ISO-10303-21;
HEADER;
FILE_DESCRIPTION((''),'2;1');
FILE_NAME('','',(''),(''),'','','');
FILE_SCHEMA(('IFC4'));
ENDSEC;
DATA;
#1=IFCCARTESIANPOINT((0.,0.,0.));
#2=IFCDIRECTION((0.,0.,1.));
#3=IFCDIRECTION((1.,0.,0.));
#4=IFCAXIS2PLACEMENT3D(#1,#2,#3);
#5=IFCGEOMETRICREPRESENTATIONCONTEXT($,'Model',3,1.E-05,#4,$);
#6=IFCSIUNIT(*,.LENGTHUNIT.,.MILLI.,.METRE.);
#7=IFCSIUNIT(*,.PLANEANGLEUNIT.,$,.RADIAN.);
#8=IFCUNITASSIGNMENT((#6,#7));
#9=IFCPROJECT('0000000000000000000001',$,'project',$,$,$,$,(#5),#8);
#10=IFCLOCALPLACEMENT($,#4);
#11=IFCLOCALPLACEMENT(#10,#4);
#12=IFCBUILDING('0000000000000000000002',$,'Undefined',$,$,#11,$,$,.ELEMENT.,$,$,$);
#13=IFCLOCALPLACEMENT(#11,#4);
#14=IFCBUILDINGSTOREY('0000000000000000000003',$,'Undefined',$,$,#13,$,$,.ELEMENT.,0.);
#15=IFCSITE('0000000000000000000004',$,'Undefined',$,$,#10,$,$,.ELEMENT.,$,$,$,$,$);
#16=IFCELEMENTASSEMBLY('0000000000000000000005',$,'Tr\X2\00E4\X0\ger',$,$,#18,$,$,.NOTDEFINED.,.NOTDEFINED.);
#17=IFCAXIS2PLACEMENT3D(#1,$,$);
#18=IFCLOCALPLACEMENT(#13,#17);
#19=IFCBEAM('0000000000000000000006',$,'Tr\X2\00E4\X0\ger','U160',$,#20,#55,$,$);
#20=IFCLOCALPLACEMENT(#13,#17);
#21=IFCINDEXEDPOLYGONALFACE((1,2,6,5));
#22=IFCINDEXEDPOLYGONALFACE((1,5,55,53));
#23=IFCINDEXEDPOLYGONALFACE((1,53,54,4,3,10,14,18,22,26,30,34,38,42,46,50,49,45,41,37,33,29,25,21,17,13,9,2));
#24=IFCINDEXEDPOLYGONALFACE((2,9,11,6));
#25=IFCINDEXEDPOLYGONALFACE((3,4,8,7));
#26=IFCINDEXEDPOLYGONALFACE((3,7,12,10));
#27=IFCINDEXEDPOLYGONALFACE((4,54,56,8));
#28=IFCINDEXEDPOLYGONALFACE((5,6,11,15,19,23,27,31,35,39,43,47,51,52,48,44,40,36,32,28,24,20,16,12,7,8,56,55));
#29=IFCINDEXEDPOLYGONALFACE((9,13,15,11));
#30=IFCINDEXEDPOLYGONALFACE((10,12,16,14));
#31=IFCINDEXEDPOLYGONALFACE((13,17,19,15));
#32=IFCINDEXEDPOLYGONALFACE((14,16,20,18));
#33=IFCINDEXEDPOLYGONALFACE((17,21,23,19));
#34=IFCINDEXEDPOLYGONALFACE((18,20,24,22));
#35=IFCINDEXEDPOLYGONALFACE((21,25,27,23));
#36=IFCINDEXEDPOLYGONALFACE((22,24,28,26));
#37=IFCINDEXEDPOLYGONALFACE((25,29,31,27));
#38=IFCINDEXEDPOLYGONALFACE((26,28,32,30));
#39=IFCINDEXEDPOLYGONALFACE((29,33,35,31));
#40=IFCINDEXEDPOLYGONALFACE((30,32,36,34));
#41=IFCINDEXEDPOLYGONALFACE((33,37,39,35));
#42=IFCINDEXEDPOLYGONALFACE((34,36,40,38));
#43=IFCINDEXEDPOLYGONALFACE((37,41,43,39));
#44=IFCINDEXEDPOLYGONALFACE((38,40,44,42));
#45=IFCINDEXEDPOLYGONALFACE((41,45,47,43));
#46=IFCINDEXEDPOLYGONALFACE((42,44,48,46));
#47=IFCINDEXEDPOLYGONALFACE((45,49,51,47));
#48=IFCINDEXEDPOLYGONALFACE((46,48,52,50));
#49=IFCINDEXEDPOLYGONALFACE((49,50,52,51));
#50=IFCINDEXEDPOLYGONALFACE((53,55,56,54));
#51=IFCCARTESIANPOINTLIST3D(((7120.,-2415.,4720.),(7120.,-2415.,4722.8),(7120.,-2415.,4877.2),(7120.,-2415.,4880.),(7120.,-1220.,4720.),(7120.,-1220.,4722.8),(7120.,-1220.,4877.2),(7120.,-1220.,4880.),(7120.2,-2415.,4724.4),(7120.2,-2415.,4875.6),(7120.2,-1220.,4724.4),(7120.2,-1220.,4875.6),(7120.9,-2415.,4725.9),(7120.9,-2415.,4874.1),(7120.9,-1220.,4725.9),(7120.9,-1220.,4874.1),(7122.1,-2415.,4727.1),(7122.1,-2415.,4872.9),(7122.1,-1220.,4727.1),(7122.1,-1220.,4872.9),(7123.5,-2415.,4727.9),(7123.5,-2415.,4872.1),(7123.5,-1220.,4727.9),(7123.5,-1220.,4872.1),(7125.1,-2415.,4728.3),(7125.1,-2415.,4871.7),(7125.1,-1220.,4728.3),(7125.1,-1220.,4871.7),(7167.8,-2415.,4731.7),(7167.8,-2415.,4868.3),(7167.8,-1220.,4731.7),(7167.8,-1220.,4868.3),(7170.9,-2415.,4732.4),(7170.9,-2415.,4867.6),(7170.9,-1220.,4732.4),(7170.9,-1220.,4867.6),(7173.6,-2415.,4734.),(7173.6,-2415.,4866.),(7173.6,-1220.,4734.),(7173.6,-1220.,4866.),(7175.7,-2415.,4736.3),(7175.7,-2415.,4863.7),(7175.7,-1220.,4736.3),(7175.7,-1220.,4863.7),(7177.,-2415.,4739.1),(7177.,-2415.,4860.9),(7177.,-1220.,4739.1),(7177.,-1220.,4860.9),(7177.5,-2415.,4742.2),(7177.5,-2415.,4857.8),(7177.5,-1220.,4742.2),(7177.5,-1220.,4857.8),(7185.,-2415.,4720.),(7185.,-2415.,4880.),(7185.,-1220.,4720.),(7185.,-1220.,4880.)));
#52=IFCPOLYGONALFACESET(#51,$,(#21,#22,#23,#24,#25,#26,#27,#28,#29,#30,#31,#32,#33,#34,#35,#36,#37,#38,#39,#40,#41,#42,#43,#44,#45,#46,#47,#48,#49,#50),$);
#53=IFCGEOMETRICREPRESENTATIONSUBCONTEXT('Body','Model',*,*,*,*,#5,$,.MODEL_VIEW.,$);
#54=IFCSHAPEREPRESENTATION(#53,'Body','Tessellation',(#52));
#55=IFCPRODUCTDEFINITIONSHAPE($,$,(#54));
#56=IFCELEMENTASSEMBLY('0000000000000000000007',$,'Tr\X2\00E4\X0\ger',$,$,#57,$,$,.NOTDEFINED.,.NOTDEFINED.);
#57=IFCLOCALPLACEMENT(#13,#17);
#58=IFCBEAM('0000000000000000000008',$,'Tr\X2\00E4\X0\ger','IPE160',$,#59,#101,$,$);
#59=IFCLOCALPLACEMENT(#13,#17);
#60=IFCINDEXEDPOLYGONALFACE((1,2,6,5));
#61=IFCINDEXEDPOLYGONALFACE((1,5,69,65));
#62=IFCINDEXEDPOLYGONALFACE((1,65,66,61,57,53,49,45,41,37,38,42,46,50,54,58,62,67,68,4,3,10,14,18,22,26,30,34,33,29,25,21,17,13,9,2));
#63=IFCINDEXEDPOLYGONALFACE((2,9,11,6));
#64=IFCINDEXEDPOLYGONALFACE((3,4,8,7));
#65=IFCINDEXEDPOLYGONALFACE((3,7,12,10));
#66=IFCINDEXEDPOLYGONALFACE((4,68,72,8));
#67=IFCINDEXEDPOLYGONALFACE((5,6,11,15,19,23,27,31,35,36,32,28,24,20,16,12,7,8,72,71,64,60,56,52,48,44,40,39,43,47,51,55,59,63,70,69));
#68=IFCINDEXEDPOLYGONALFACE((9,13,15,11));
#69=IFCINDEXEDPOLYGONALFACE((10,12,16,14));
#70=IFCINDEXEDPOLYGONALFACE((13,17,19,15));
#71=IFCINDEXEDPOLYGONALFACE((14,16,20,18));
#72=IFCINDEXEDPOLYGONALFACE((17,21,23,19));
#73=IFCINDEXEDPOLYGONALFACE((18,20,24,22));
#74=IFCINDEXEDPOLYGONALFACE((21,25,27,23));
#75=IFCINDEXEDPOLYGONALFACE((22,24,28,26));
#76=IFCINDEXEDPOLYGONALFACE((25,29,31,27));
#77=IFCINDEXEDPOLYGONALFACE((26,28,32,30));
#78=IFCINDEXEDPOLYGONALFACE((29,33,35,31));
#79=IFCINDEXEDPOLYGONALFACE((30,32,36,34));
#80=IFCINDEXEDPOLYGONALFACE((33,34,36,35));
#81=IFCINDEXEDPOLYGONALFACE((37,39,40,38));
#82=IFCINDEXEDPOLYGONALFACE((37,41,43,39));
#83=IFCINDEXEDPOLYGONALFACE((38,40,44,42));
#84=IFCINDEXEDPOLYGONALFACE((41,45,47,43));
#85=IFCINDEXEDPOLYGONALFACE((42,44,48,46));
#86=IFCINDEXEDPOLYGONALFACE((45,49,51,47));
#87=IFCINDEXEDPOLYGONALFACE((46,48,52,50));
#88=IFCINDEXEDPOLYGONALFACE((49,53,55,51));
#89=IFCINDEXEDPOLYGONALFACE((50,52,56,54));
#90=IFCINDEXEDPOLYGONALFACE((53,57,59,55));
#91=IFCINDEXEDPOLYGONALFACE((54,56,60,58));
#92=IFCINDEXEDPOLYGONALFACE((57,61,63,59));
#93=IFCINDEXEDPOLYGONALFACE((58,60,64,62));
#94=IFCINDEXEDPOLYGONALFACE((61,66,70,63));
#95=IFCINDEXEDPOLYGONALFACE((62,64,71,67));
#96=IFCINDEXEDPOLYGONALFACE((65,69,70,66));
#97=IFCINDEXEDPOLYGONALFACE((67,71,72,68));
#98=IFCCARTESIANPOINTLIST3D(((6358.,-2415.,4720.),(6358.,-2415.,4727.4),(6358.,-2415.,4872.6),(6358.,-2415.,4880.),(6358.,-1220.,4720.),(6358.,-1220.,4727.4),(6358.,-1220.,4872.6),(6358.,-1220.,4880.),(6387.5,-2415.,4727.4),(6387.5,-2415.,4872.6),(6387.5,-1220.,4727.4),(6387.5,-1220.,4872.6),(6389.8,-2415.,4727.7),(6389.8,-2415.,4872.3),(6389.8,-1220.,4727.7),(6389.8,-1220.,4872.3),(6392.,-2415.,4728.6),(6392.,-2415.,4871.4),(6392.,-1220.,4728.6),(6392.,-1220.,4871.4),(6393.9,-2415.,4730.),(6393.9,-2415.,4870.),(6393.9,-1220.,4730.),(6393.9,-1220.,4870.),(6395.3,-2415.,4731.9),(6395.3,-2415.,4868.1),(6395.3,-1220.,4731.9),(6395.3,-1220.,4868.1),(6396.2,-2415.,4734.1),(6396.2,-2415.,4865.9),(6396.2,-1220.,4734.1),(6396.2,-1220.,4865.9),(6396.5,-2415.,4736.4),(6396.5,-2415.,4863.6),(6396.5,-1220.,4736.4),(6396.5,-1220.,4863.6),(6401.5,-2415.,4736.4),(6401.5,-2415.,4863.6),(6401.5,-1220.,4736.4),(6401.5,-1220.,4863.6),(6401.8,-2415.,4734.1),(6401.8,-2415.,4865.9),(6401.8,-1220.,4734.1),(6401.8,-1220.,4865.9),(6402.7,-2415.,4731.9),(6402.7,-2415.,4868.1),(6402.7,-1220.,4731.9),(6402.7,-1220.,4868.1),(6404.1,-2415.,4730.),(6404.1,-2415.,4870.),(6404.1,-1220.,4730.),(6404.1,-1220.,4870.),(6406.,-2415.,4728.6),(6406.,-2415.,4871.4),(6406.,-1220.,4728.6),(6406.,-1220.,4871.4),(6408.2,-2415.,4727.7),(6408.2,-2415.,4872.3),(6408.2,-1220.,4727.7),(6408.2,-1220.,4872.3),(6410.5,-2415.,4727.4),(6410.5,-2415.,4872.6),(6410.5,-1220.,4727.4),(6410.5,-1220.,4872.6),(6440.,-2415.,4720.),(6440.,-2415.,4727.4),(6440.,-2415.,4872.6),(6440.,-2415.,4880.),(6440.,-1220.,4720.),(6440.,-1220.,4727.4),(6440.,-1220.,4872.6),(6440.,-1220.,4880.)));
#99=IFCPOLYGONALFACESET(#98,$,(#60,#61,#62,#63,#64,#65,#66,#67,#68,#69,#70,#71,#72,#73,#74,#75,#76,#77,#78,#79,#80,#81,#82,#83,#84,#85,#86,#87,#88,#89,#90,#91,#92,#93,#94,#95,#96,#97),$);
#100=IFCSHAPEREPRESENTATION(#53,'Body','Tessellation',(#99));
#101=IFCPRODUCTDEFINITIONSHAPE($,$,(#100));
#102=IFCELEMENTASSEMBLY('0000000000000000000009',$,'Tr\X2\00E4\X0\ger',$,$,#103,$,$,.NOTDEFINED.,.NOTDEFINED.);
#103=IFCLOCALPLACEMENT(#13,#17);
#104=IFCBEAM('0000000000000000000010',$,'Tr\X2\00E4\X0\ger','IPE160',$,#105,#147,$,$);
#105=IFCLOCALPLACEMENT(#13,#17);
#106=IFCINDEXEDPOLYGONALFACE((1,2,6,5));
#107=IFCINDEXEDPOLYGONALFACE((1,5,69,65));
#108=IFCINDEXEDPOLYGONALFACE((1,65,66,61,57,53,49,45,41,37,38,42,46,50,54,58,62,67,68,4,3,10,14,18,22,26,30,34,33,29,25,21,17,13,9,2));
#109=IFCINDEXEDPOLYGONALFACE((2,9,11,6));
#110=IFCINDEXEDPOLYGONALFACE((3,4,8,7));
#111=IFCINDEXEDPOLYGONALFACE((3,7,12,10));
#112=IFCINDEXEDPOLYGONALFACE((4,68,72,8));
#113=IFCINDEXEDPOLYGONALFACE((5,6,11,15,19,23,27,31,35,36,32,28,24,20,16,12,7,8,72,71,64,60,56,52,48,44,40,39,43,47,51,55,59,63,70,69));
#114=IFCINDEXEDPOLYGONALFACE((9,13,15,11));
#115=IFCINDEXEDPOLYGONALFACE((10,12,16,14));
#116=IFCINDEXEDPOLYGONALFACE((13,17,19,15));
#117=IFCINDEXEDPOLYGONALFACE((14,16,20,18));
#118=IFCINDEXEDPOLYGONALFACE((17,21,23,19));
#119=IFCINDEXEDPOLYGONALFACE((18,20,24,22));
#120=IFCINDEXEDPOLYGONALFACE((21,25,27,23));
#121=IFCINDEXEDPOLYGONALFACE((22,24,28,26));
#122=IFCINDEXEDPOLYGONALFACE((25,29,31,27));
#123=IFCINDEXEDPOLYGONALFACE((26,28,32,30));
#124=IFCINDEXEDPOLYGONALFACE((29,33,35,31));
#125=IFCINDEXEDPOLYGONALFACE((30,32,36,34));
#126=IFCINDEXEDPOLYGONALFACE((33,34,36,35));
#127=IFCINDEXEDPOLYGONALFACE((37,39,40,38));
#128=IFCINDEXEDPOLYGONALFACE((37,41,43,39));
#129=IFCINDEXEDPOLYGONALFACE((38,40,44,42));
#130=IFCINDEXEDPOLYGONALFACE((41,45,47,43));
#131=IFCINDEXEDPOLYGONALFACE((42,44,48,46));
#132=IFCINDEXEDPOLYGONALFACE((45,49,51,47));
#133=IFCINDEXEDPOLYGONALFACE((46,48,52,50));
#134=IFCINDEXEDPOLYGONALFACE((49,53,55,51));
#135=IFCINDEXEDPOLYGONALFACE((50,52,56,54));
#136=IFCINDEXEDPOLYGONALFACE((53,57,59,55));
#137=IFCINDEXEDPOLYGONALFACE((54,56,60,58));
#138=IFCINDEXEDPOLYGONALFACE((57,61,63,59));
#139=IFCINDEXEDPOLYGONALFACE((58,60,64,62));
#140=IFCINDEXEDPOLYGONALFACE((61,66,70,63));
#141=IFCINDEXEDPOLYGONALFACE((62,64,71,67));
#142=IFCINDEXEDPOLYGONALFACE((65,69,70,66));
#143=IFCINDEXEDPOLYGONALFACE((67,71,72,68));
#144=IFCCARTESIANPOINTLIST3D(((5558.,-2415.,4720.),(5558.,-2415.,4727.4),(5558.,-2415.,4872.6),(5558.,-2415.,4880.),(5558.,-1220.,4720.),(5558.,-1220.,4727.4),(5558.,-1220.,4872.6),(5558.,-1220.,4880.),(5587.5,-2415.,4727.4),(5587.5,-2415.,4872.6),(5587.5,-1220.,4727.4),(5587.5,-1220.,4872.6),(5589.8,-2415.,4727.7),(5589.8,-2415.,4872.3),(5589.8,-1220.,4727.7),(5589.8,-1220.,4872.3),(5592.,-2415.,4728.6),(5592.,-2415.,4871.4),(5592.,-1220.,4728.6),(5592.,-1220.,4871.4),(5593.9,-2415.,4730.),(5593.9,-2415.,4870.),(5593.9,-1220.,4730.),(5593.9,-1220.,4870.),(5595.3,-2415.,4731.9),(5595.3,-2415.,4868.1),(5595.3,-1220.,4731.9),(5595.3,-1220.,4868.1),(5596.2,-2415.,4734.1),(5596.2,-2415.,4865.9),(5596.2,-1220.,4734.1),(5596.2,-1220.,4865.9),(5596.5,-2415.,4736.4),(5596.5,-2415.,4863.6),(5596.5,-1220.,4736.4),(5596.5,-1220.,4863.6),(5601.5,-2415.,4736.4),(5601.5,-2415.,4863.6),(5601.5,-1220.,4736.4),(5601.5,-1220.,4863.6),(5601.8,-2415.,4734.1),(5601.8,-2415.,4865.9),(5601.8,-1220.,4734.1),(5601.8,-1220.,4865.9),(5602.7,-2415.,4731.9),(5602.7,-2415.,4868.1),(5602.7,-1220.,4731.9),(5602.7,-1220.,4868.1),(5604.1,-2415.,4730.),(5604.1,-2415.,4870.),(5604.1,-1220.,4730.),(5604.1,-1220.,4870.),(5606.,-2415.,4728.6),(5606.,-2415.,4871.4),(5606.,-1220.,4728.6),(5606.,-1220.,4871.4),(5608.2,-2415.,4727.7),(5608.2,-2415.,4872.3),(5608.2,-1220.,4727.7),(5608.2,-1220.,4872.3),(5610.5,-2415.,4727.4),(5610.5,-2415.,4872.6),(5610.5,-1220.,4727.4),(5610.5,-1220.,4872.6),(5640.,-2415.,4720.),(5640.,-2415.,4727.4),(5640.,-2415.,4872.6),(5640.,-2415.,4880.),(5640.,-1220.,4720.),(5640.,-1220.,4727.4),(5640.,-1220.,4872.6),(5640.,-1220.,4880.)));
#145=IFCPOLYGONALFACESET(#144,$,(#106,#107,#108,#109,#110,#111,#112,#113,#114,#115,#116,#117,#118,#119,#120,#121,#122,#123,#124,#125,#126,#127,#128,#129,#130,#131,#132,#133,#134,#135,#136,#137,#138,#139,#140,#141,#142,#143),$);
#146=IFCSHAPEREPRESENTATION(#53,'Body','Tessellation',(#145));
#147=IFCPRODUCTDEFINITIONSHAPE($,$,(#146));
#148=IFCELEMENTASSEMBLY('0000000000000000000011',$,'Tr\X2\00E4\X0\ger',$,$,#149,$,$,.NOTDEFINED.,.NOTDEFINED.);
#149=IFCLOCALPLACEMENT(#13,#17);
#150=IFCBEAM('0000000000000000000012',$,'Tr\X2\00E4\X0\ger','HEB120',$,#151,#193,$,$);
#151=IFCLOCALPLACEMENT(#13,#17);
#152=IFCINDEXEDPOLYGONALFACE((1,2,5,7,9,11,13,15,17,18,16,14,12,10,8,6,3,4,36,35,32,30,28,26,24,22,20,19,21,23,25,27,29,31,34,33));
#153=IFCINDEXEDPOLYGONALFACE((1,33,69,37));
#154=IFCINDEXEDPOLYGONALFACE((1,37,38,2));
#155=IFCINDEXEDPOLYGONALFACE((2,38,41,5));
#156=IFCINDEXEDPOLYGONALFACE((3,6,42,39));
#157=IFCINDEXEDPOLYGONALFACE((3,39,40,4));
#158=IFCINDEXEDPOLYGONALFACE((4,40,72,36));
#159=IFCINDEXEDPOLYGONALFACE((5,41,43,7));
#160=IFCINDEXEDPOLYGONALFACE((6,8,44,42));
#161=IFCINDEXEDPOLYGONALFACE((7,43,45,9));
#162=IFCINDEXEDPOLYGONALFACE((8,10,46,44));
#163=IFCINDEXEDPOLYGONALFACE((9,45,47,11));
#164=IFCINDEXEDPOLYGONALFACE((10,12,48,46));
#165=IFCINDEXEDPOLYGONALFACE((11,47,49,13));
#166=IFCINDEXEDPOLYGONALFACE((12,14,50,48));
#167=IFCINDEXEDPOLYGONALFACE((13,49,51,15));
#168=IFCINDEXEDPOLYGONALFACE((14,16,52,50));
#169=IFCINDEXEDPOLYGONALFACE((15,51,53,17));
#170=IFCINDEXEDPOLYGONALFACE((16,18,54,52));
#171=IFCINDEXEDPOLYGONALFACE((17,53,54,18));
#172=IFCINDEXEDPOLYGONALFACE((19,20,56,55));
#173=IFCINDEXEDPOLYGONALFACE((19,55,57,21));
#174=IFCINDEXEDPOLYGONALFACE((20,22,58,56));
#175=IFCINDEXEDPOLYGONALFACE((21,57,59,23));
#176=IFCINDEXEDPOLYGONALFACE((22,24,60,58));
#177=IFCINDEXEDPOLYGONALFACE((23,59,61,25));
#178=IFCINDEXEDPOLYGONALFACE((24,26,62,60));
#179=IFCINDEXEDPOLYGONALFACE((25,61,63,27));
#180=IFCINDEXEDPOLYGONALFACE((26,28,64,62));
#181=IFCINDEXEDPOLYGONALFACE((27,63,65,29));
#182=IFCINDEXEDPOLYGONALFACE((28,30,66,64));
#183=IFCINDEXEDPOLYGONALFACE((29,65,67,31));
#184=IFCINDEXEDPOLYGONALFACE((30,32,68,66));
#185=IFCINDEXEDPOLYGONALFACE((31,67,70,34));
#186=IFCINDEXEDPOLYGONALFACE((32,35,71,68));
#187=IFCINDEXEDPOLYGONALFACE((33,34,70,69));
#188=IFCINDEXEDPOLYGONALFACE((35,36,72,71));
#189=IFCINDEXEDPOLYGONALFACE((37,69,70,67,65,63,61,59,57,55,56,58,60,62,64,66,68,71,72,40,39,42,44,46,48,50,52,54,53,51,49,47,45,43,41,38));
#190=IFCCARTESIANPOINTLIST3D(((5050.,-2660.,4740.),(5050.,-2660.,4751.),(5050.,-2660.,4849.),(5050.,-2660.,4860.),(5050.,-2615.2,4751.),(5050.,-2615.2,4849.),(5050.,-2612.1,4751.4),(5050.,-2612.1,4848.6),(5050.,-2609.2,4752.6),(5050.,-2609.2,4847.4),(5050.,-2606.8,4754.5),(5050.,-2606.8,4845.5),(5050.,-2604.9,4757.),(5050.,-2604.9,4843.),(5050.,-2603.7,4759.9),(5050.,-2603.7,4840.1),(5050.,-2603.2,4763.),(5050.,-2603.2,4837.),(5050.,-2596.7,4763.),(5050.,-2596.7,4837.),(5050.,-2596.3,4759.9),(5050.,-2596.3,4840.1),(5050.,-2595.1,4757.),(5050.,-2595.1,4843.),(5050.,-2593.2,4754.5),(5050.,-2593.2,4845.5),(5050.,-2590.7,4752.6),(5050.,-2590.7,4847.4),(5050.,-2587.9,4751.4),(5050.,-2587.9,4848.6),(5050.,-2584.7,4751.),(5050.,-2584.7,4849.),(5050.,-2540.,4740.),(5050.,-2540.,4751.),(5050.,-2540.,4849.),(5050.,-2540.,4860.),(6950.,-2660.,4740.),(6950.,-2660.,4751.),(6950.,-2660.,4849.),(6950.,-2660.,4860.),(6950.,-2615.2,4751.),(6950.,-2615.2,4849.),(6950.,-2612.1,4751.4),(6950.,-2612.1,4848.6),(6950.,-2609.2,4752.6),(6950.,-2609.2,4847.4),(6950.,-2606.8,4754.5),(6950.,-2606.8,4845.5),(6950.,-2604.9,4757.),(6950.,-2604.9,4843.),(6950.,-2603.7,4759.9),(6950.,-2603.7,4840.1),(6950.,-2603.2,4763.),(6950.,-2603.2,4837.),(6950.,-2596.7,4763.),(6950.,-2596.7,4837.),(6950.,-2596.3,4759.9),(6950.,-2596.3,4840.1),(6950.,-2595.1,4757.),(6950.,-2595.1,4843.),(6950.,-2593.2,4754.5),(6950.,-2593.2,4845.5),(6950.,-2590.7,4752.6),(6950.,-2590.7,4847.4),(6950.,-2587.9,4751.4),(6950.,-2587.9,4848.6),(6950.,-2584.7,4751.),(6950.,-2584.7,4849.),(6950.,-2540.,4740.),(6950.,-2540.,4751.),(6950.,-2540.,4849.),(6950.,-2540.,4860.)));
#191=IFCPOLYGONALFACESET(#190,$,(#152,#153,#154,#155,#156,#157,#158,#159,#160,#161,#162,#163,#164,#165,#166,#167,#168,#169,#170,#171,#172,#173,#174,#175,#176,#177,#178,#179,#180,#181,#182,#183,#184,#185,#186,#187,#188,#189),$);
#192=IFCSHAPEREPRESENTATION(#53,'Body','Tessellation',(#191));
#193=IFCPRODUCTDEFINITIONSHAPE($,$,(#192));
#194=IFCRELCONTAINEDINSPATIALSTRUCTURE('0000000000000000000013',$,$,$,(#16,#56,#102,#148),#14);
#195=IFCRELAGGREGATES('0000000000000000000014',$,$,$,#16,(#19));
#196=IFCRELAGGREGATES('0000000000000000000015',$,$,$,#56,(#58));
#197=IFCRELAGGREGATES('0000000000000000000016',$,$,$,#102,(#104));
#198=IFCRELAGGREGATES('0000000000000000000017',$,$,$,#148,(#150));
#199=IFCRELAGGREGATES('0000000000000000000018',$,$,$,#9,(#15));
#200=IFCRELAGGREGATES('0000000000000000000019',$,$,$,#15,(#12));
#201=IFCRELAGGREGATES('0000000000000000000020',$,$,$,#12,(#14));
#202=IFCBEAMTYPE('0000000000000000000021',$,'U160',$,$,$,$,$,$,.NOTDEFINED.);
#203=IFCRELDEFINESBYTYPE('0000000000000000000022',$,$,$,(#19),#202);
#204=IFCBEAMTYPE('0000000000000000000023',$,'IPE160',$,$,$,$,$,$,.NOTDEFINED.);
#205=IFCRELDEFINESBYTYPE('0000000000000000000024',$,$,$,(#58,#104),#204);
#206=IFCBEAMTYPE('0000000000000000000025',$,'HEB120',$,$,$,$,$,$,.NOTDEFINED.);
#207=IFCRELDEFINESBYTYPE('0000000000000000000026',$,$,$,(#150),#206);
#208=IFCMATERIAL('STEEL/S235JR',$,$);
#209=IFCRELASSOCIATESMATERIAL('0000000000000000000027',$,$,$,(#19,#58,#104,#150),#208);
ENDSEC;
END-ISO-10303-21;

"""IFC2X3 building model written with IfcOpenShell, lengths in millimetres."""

from ifc_helpers import new_model, si_unit, frame, origin_with_axes, origin_2d_with_axis, place, context, subcontext, project, spatial, i_section, u_section, extrude, clip, halfspace, material, type_object, element, aggregate, save


model = new_model("IFC2X3")

# Units and contexts
model_context = context("Model", 3, precision=1e-05, world=origin_with_axes())
body_context = subcontext(model_context, "Body", "Model", "MODEL_VIEW")
ifc_project = project(units=[si_unit("LENGTHUNIT", "METRE", prefix="MILLI"), si_unit("PLANEANGLEUNIT", "RADIAN")], contexts=[model_context])

# Site, building, storey
site_placement = place(None, origin_with_axes())
site = spatial("IfcSite", under=ifc_project, at=site_placement, Name="Undefined", CompositionType="ELEMENT")
building_placement = place(site_placement, origin_with_axes())
building = spatial("IfcBuilding", under=site, at=building_placement, Name="Undefined", CompositionType="ELEMENT")
storey_placement = place(building_placement, origin_with_axes())
storey = spatial("IfcBuildingStorey", under=building, at=storey_placement, Name="Undefined", CompositionType="ELEMENT", Elevation=0.0)

# Element assemblies, beams
ifc_material_1 = material(Name="STEEL/S235JR")
assembly_1_placement = place(storey_placement, origin_with_axes())
assembly_1 = element("IfcElementAssembly", 1, at=assembly_1_placement, inside=storey, Name="Träger", AssemblyPlace="NOTDEFINED", PredefinedType="NOTDEFINED")
beam_type_1 = type_object("IfcBeamType", Name="U160", PredefinedType="NOTDEFINED")
beam_1_placement = place(assembly_1_placement, frame((7152.5, -1220.0, 4800.0), z_axis=(0.0, 0.0, 1.0), x_axis=(0.0, -1.0, 0.0)))
beam_1 = element("IfcBeam", 2, at=beam_1_placement, type_object=beam_type_1, material=ifc_material_1, Name="Träger", Description="U160", context=body_context, shape_type="SweptSolid", body=[
    extrude(u_section(Depth=160.0, FlangeWidth=65.0, WebThickness=7.5, FlangeThickness=10.5, FilletRadius=10.5, EdgeRadius=5.5, FlangeSlope=0.07983, at=origin_2d_with_axis()), frame((1195.0, 0.0, 0.0), z_axis=(-1.0, 0.0, 0.0), x_axis=(0.0, -1.0, 0.0)), (0.0, 0.0, 1.0), 1195.0),
])
aggregate(assembly_1, [beam_1])
assembly_2_placement = place(storey_placement, origin_with_axes())
assembly_2 = element("IfcElementAssembly", 3, at=assembly_2_placement, inside=storey, Name="Träger", AssemblyPlace="NOTDEFINED", PredefinedType="NOTDEFINED")
beam_type_2 = type_object("IfcBeamType", Name="IPE160", PredefinedType="NOTDEFINED")
beam_2_placement = place(assembly_2_placement, frame((6399.0, -1220.0, 4800.0), z_axis=(0.0, 0.0, -1.0), x_axis=(0.0, -1.0, 0.0)))
beam_2 = element("IfcBeam", 4, at=beam_2_placement, type_object=beam_type_2, material=ifc_material_1, Name="Träger", Description="IPE160", context=body_context, shape_type="SweptSolid", body=[
    extrude(i_section(OverallWidth=82.0, OverallDepth=160.0, WebThickness=5.0, FlangeThickness=7.4, FilletRadius=9.0, at=origin_2d_with_axis()), frame((1195.0, 0.0, 0.0), z_axis=(-1.0, 0.0, 0.0), x_axis=(0.0, -1.0, 0.0)), (0.0, 0.0, 1.0), 1195.0),
])
aggregate(assembly_2, [beam_2])
assembly_3_placement = place(storey_placement, origin_with_axes())
assembly_3 = element("IfcElementAssembly", 5, at=assembly_3_placement, inside=storey, Name="Träger", AssemblyPlace="NOTDEFINED", PredefinedType="NOTDEFINED")
beam_3_placement = place(assembly_3_placement, frame((5599.0, -1220.0, 4800.0), z_axis=(0.0, 0.0, -1.0), x_axis=(0.0, -1.0, 0.0)))
beam_3 = element("IfcBeam", 6, at=beam_3_placement, type_object=beam_type_2, material=ifc_material_1, Name="Träger", Description="IPE160", context=body_context, shape_type="SweptSolid", body=[
    extrude(i_section(OverallWidth=82.0, OverallDepth=160.0, WebThickness=5.0, FlangeThickness=7.4, FilletRadius=9.0, at=origin_2d_with_axis()), frame((1195.0, 0.0, 0.0), z_axis=(-1.0, 0.0, 0.0), x_axis=(0.0, -1.0, 0.0)), (0.0, 0.0, 1.0), 1195.0),
])
aggregate(assembly_3, [beam_3])
beam_type_3 = type_object("IfcBeamType", Name="HEB120", PredefinedType="NOTDEFINED")
assembly_4_placement = place(storey_placement, origin_with_axes())
assembly_4 = element("IfcElementAssembly", 7, at=assembly_4_placement, inside=storey, Name="Träger", AssemblyPlace="NOTDEFINED", PredefinedType="NOTDEFINED")
beam_4_placement = place(assembly_4_placement, frame((6950.0, -2600.0, 4800.0), z_axis=(0.0, 0.0, 1.0), x_axis=(-1.0, 0.0, 0.0)))
beam_4 = element("IfcBeam", 8, at=beam_4_placement, type_object=beam_type_3, material=ifc_material_1, Name="Träger", Description="HEB120", context=body_context, shape_type="Clipping", body=[
    clip(clip(extrude(i_section(OverallWidth=120.0, OverallDepth=120.0, WebThickness=6.5, FlangeThickness=11.0, FilletRadius=12.0, at=origin_2d_with_axis()), frame((1910.0, 0.0, 0.0), z_axis=(-1.0, 0.0, 0.0), x_axis=(0.0, -1.0, 0.0)), (0.0, 0.0, 1.0), 1910.0), halfspace(frame((1900.0, 0.0, -60.0), z_axis=(-1.0, 0.0, 0.0), x_axis=(0.0, 1.0, 0.0)), True)), halfspace(frame((0.0, 0.0, -60.0), z_axis=(1.0, 0.0, 0.0), x_axis=(0.0, -1.0, 0.0)), True)),
])

aggregate(assembly_4, [beam_4])

save(model, "model.ifc")
